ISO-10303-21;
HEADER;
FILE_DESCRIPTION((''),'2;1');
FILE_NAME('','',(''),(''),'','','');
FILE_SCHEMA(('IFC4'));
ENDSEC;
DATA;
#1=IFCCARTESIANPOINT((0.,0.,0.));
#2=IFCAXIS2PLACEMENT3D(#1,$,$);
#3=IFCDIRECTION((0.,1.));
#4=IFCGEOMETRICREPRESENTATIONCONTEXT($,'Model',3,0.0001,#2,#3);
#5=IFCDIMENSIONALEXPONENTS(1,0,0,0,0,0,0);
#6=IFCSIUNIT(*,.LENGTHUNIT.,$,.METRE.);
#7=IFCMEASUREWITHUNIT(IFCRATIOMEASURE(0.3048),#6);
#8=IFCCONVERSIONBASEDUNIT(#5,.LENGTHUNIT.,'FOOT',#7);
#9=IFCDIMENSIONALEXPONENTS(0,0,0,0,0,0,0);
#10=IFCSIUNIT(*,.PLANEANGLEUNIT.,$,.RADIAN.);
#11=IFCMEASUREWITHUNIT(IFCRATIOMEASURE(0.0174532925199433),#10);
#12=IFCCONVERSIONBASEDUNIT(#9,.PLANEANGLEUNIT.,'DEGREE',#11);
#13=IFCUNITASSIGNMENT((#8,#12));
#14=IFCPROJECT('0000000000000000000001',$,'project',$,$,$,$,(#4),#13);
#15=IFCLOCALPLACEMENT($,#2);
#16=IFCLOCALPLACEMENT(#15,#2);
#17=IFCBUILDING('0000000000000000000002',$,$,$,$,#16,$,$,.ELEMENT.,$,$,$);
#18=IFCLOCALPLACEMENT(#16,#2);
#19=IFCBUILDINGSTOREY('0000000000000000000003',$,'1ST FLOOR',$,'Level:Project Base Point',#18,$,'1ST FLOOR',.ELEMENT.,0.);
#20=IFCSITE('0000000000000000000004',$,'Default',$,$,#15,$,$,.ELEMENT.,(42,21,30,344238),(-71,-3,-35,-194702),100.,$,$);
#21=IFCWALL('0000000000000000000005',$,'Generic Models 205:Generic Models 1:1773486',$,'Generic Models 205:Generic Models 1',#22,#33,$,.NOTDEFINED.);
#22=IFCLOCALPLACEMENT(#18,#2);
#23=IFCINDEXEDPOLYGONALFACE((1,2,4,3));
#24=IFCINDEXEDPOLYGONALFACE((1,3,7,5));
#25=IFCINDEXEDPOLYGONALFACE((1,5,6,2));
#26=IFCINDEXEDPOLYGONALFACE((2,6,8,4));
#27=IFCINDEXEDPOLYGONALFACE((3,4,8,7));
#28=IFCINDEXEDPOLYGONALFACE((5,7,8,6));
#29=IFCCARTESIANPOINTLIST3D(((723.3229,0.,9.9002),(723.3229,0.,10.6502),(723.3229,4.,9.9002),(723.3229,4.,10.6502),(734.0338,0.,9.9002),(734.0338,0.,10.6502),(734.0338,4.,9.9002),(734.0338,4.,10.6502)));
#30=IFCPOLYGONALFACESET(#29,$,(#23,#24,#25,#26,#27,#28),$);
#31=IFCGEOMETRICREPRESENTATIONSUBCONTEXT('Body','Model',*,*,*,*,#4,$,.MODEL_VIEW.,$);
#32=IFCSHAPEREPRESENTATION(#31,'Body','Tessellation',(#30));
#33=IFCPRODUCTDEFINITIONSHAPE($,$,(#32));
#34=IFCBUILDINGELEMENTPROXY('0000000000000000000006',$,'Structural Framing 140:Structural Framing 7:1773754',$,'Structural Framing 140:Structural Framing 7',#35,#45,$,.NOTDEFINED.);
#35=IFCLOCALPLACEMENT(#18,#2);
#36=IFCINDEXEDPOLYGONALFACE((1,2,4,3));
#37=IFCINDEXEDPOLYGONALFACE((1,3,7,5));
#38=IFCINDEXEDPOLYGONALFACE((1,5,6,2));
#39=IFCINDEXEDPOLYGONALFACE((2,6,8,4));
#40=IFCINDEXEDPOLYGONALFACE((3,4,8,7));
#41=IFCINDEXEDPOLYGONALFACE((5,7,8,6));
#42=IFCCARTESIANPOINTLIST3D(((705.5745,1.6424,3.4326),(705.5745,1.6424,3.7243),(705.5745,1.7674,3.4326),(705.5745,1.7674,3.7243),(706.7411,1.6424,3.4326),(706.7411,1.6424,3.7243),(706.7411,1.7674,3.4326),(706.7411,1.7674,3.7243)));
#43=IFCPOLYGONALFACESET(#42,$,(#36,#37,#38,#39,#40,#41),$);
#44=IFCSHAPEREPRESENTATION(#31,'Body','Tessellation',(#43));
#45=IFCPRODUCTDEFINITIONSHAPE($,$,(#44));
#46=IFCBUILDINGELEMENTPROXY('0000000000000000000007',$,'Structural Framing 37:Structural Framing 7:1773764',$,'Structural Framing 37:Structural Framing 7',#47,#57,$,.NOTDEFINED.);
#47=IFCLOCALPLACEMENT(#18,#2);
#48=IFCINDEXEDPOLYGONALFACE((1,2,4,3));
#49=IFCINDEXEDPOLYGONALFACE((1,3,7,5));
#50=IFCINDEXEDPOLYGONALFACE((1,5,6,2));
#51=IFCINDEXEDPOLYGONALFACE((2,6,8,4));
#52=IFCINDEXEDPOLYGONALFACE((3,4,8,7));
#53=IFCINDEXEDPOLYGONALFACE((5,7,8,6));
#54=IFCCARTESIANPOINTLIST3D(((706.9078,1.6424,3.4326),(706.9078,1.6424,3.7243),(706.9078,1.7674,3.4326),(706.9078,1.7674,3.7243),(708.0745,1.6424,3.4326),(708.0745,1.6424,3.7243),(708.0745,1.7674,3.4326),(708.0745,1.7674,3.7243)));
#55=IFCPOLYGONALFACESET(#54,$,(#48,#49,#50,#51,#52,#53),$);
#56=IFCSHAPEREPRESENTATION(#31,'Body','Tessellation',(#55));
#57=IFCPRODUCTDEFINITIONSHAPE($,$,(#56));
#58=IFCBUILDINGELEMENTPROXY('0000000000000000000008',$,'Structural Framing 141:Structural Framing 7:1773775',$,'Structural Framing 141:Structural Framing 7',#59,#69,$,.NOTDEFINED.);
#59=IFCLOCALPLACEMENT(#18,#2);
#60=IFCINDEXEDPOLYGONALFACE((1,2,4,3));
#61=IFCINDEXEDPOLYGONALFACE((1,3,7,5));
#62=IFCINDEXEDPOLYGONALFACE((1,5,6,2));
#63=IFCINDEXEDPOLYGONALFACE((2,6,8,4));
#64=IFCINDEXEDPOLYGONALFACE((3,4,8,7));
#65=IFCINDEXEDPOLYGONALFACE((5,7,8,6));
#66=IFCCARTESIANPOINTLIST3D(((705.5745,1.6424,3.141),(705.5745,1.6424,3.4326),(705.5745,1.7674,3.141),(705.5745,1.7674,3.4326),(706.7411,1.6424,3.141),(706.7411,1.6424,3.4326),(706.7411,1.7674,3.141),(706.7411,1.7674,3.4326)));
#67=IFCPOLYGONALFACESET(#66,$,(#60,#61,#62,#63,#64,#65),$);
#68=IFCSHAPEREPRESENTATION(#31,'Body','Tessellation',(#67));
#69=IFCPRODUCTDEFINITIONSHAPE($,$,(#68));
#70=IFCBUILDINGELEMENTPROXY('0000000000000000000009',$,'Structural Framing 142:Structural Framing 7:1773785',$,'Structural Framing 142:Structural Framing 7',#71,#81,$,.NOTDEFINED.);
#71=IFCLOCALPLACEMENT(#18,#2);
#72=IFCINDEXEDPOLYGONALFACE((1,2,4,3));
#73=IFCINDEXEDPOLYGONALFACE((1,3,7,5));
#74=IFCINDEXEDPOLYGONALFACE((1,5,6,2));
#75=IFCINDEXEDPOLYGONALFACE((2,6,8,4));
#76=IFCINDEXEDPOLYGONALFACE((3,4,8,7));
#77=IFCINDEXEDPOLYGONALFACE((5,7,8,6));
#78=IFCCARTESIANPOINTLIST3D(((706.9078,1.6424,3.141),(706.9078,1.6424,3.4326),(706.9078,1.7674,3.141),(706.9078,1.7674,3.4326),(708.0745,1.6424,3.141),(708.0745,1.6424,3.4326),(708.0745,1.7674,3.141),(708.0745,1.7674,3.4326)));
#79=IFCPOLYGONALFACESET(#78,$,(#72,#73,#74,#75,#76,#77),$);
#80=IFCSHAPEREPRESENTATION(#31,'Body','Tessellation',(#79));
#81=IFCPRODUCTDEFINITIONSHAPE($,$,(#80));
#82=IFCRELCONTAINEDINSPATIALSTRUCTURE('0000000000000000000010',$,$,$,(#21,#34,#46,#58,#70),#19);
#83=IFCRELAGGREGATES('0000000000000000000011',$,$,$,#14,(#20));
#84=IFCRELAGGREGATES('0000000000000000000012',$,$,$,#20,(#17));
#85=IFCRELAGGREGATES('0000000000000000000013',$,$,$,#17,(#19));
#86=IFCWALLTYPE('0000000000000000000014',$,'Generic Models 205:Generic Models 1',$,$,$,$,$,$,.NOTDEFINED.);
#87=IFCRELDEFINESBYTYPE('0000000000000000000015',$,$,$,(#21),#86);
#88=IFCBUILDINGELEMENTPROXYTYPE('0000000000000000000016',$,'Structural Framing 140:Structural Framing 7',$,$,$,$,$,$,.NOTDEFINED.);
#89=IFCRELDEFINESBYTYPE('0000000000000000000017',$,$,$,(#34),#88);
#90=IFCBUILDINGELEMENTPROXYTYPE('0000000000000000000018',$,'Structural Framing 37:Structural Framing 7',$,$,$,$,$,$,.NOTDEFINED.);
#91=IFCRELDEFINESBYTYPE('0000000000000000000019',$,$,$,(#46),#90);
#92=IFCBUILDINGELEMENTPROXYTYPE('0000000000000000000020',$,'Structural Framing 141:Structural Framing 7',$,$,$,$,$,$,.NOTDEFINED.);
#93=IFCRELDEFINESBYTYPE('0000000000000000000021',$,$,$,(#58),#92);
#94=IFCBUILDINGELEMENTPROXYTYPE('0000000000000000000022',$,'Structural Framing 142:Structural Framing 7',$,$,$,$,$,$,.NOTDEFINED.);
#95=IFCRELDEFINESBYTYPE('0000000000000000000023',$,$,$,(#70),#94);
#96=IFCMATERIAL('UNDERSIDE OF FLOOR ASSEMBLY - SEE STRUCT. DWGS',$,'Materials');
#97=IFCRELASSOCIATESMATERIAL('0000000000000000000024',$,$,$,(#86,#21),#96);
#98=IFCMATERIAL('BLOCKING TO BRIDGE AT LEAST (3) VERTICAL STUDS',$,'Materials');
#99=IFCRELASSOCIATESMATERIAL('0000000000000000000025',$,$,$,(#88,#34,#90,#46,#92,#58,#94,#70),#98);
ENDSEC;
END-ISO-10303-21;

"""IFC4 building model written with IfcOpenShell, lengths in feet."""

from ifc_helpers import new_model, entity, si_unit, converted_unit, direction, frame, frame_2d, origin, place, context, subcontext, project, spatial, rectangle, extrude, source, transform, mapped, material, type_object, type_shapes, element, save


model = new_model("IFC4")

# Units and contexts
model_context = context("Model", 3, precision=0.0001, world=origin(), true_north=direction((0.0, 1.0)))
body_context = subcontext(model_context, "Body", "Model", "MODEL_VIEW")
ifc_project = project(units=[converted_unit("LENGTHUNIT", "FOOT", entity("IfcRatioMeasure", 0.3048), si_unit("LENGTHUNIT", "METRE"), dimensions=[1, 0, 0, 0, 0, 0, 0]), converted_unit("PLANEANGLEUNIT", "DEGREE", entity("IfcRatioMeasure", 0.0174532925199433), si_unit("PLANEANGLEUNIT", "RADIAN"), dimensions=[0, 0, 0, 0, 0, 0, 0])], contexts=[model_context])

# Site, building, storey
site_placement = place(None, origin())
site = spatial("IfcSite", under=ifc_project, at=site_placement, Name="Default", CompositionType="ELEMENT", RefLatitude=(42, 21, 30, 344238), RefLongitude=(-71, -3, -35, -194702), RefElevation=100.0)
building_placement = place(site_placement, origin())
building = spatial("IfcBuilding", under=site, at=building_placement, CompositionType="ELEMENT")
storey_placement = place(building_placement, origin())
storey = spatial("IfcBuildingStorey", under=building, at=storey_placement, Name="1ST FLOOR", ObjectType="Level:Project Base Point", LongName="1ST FLOOR", CompositionType="ELEMENT", Elevation=0.0)

# Wall
ifc_material_1 = material(Name="UNDERSIDE OF FLOOR ASSEMBLY - SEE STRUCT. DWGS", Category="Materials")
wall_type = type_object("IfcWallType", Name="Generic Models 205:Generic Models 1", PredefinedType="NOTDEFINED", material=ifc_material_1)
wall_placement = place(storey_placement, frame((723.3229, 0.0, 9.9002)))
element("IfcWall", 1, at=wall_placement, inside=storey, type_object=wall_type, material=ifc_material_1, Name="Generic Models 205:Generic Models 1:1773486", ObjectType="Generic Models 205:Generic Models 1", PredefinedType="NOTDEFINED", context=body_context, shape_type="SweptSolid", body=[
    extrude(rectangle(XDim=4.0, YDim=10.7109, at=frame_2d((0.0, 0.0), x_axis=(1.0, 0.0))), frame((5.3554, 2.0, 0.0), z_axis=(0.0, 0.0, 1.0), x_axis=(0.0, 1.0, 0.0)), (0.0, 0.0, 1.0), 0.75),
])

# Building element proxies
ifc_material_2 = material(Name="BLOCKING TO BRIDGE AT LEAST (3) VERTICAL STUDS", Category="Materials")
building_element_proxy_type_1 = type_object("IfcBuildingElementProxyType", Name="Structural Framing 140:Structural Framing 7", PredefinedType="NOTDEFINED", material=ifc_material_2)
shared_shape_1 = source(origin(), body_context, "Body", "SweptSolid", [
    extrude(rectangle(XDim=1.1667, YDim=0.125, at=frame_2d((0.0, 0.0), x_axis=(1.0, 0.0))), frame((0.5833, 0.0625, 0.0), z_axis=(0.0, 0.0, 1.0), x_axis=(-1.0, 0.0, 0.0)), (0.0, 0.0, 1.0), 0.2917),
])
type_shapes(building_element_proxy_type_1, [shared_shape_1])
proxy_1_placement = place(storey_placement, frame((705.5745, 1.6424, 3.4326)))
element("IfcBuildingElementProxy", 2, at=proxy_1_placement, inside=storey, type_object=building_element_proxy_type_1, material=ifc_material_2, Name="Structural Framing 140:Structural Framing 7:1773754", ObjectType="Structural Framing 140:Structural Framing 7", PredefinedType="NOTDEFINED", context=body_context, shape_type="MappedRepresentation", body=[
    mapped(shared_shape_1, transform((0.0, 0.0, 0.0), scale=1.0)),
])
building_element_proxy_type_2 = type_object("IfcBuildingElementProxyType", Name="Structural Framing 37:Structural Framing 7", PredefinedType="NOTDEFINED", material=ifc_material_2)
shared_shape_2 = source(origin(), body_context, "Body", "SweptSolid", [
    extrude(rectangle(XDim=1.1667, YDim=0.125, at=frame_2d((0.0, 0.0), x_axis=(1.0, 0.0))), frame((0.5833, 0.0625, 0.0), z_axis=(0.0, 0.0, 1.0), x_axis=(-1.0, 0.0, 0.0)), (0.0, 0.0, 1.0), 0.2917),
])
type_shapes(building_element_proxy_type_2, [shared_shape_2])
proxy_2_placement = place(storey_placement, frame((706.9078, 1.6424, 3.4326)))
element("IfcBuildingElementProxy", 3, at=proxy_2_placement, inside=storey, type_object=building_element_proxy_type_2, material=ifc_material_2, Name="Structural Framing 37:Structural Framing 7:1773764", ObjectType="Structural Framing 37:Structural Framing 7", PredefinedType="NOTDEFINED", context=body_context, shape_type="MappedRepresentation", body=[
    mapped(shared_shape_2, transform((0.0, 0.0, 0.0), scale=1.0)),
])
building_element_proxy_type_3 = type_object("IfcBuildingElementProxyType", Name="Structural Framing 141:Structural Framing 7", PredefinedType="NOTDEFINED", material=ifc_material_2)
shared_shape_3 = source(origin(), body_context, "Body", "SweptSolid", [
    extrude(rectangle(XDim=1.1667, YDim=0.125, at=frame_2d((0.0, 0.0), x_axis=(1.0, 0.0))), frame((0.5833, 0.0625, 0.0), z_axis=(0.0, 0.0, 1.0), x_axis=(-1.0, 0.0, 0.0)), (0.0, 0.0, 1.0), 0.2917),
])
type_shapes(building_element_proxy_type_3, [shared_shape_3])
proxy_3_placement = place(storey_placement, frame((705.5745, 1.6424, 3.141)))
element("IfcBuildingElementProxy", 4, at=proxy_3_placement, inside=storey, type_object=building_element_proxy_type_3, material=ifc_material_2, Name="Structural Framing 141:Structural Framing 7:1773775", ObjectType="Structural Framing 141:Structural Framing 7", PredefinedType="NOTDEFINED", context=body_context, shape_type="MappedRepresentation", body=[
    mapped(shared_shape_3, transform((0.0, 0.0, 0.0), scale=1.0)),
])
building_element_proxy_type_4 = type_object("IfcBuildingElementProxyType", Name="Structural Framing 142:Structural Framing 7", PredefinedType="NOTDEFINED", material=ifc_material_2)
shared_shape_4 = source(origin(), body_context, "Body", "SweptSolid", [
    extrude(rectangle(XDim=1.1667, YDim=0.125, at=frame_2d((0.0, 0.0), x_axis=(1.0, 0.0))), frame((0.5833, 0.0625, 0.0), z_axis=(0.0, 0.0, 1.0), x_axis=(-1.0, 0.0, 0.0)), (0.0, 0.0, 1.0), 0.2917),
])
type_shapes(building_element_proxy_type_4, [shared_shape_4])
proxy_4_placement = place(storey_placement, frame((706.9078, 1.6424, 3.141)))
element("IfcBuildingElementProxy", 5, at=proxy_4_placement, inside=storey, type_object=building_element_proxy_type_4, material=ifc_material_2, Name="Structural Framing 142:Structural Framing 7:1773785", ObjectType="Structural Framing 142:Structural Framing 7", PredefinedType="NOTDEFINED", context=body_context, shape_type="MappedRepresentation", body=[
    mapped(shared_shape_4, transform((0.0, 0.0, 0.0), scale=1.0)),
])

save(model, "model.ifc")
